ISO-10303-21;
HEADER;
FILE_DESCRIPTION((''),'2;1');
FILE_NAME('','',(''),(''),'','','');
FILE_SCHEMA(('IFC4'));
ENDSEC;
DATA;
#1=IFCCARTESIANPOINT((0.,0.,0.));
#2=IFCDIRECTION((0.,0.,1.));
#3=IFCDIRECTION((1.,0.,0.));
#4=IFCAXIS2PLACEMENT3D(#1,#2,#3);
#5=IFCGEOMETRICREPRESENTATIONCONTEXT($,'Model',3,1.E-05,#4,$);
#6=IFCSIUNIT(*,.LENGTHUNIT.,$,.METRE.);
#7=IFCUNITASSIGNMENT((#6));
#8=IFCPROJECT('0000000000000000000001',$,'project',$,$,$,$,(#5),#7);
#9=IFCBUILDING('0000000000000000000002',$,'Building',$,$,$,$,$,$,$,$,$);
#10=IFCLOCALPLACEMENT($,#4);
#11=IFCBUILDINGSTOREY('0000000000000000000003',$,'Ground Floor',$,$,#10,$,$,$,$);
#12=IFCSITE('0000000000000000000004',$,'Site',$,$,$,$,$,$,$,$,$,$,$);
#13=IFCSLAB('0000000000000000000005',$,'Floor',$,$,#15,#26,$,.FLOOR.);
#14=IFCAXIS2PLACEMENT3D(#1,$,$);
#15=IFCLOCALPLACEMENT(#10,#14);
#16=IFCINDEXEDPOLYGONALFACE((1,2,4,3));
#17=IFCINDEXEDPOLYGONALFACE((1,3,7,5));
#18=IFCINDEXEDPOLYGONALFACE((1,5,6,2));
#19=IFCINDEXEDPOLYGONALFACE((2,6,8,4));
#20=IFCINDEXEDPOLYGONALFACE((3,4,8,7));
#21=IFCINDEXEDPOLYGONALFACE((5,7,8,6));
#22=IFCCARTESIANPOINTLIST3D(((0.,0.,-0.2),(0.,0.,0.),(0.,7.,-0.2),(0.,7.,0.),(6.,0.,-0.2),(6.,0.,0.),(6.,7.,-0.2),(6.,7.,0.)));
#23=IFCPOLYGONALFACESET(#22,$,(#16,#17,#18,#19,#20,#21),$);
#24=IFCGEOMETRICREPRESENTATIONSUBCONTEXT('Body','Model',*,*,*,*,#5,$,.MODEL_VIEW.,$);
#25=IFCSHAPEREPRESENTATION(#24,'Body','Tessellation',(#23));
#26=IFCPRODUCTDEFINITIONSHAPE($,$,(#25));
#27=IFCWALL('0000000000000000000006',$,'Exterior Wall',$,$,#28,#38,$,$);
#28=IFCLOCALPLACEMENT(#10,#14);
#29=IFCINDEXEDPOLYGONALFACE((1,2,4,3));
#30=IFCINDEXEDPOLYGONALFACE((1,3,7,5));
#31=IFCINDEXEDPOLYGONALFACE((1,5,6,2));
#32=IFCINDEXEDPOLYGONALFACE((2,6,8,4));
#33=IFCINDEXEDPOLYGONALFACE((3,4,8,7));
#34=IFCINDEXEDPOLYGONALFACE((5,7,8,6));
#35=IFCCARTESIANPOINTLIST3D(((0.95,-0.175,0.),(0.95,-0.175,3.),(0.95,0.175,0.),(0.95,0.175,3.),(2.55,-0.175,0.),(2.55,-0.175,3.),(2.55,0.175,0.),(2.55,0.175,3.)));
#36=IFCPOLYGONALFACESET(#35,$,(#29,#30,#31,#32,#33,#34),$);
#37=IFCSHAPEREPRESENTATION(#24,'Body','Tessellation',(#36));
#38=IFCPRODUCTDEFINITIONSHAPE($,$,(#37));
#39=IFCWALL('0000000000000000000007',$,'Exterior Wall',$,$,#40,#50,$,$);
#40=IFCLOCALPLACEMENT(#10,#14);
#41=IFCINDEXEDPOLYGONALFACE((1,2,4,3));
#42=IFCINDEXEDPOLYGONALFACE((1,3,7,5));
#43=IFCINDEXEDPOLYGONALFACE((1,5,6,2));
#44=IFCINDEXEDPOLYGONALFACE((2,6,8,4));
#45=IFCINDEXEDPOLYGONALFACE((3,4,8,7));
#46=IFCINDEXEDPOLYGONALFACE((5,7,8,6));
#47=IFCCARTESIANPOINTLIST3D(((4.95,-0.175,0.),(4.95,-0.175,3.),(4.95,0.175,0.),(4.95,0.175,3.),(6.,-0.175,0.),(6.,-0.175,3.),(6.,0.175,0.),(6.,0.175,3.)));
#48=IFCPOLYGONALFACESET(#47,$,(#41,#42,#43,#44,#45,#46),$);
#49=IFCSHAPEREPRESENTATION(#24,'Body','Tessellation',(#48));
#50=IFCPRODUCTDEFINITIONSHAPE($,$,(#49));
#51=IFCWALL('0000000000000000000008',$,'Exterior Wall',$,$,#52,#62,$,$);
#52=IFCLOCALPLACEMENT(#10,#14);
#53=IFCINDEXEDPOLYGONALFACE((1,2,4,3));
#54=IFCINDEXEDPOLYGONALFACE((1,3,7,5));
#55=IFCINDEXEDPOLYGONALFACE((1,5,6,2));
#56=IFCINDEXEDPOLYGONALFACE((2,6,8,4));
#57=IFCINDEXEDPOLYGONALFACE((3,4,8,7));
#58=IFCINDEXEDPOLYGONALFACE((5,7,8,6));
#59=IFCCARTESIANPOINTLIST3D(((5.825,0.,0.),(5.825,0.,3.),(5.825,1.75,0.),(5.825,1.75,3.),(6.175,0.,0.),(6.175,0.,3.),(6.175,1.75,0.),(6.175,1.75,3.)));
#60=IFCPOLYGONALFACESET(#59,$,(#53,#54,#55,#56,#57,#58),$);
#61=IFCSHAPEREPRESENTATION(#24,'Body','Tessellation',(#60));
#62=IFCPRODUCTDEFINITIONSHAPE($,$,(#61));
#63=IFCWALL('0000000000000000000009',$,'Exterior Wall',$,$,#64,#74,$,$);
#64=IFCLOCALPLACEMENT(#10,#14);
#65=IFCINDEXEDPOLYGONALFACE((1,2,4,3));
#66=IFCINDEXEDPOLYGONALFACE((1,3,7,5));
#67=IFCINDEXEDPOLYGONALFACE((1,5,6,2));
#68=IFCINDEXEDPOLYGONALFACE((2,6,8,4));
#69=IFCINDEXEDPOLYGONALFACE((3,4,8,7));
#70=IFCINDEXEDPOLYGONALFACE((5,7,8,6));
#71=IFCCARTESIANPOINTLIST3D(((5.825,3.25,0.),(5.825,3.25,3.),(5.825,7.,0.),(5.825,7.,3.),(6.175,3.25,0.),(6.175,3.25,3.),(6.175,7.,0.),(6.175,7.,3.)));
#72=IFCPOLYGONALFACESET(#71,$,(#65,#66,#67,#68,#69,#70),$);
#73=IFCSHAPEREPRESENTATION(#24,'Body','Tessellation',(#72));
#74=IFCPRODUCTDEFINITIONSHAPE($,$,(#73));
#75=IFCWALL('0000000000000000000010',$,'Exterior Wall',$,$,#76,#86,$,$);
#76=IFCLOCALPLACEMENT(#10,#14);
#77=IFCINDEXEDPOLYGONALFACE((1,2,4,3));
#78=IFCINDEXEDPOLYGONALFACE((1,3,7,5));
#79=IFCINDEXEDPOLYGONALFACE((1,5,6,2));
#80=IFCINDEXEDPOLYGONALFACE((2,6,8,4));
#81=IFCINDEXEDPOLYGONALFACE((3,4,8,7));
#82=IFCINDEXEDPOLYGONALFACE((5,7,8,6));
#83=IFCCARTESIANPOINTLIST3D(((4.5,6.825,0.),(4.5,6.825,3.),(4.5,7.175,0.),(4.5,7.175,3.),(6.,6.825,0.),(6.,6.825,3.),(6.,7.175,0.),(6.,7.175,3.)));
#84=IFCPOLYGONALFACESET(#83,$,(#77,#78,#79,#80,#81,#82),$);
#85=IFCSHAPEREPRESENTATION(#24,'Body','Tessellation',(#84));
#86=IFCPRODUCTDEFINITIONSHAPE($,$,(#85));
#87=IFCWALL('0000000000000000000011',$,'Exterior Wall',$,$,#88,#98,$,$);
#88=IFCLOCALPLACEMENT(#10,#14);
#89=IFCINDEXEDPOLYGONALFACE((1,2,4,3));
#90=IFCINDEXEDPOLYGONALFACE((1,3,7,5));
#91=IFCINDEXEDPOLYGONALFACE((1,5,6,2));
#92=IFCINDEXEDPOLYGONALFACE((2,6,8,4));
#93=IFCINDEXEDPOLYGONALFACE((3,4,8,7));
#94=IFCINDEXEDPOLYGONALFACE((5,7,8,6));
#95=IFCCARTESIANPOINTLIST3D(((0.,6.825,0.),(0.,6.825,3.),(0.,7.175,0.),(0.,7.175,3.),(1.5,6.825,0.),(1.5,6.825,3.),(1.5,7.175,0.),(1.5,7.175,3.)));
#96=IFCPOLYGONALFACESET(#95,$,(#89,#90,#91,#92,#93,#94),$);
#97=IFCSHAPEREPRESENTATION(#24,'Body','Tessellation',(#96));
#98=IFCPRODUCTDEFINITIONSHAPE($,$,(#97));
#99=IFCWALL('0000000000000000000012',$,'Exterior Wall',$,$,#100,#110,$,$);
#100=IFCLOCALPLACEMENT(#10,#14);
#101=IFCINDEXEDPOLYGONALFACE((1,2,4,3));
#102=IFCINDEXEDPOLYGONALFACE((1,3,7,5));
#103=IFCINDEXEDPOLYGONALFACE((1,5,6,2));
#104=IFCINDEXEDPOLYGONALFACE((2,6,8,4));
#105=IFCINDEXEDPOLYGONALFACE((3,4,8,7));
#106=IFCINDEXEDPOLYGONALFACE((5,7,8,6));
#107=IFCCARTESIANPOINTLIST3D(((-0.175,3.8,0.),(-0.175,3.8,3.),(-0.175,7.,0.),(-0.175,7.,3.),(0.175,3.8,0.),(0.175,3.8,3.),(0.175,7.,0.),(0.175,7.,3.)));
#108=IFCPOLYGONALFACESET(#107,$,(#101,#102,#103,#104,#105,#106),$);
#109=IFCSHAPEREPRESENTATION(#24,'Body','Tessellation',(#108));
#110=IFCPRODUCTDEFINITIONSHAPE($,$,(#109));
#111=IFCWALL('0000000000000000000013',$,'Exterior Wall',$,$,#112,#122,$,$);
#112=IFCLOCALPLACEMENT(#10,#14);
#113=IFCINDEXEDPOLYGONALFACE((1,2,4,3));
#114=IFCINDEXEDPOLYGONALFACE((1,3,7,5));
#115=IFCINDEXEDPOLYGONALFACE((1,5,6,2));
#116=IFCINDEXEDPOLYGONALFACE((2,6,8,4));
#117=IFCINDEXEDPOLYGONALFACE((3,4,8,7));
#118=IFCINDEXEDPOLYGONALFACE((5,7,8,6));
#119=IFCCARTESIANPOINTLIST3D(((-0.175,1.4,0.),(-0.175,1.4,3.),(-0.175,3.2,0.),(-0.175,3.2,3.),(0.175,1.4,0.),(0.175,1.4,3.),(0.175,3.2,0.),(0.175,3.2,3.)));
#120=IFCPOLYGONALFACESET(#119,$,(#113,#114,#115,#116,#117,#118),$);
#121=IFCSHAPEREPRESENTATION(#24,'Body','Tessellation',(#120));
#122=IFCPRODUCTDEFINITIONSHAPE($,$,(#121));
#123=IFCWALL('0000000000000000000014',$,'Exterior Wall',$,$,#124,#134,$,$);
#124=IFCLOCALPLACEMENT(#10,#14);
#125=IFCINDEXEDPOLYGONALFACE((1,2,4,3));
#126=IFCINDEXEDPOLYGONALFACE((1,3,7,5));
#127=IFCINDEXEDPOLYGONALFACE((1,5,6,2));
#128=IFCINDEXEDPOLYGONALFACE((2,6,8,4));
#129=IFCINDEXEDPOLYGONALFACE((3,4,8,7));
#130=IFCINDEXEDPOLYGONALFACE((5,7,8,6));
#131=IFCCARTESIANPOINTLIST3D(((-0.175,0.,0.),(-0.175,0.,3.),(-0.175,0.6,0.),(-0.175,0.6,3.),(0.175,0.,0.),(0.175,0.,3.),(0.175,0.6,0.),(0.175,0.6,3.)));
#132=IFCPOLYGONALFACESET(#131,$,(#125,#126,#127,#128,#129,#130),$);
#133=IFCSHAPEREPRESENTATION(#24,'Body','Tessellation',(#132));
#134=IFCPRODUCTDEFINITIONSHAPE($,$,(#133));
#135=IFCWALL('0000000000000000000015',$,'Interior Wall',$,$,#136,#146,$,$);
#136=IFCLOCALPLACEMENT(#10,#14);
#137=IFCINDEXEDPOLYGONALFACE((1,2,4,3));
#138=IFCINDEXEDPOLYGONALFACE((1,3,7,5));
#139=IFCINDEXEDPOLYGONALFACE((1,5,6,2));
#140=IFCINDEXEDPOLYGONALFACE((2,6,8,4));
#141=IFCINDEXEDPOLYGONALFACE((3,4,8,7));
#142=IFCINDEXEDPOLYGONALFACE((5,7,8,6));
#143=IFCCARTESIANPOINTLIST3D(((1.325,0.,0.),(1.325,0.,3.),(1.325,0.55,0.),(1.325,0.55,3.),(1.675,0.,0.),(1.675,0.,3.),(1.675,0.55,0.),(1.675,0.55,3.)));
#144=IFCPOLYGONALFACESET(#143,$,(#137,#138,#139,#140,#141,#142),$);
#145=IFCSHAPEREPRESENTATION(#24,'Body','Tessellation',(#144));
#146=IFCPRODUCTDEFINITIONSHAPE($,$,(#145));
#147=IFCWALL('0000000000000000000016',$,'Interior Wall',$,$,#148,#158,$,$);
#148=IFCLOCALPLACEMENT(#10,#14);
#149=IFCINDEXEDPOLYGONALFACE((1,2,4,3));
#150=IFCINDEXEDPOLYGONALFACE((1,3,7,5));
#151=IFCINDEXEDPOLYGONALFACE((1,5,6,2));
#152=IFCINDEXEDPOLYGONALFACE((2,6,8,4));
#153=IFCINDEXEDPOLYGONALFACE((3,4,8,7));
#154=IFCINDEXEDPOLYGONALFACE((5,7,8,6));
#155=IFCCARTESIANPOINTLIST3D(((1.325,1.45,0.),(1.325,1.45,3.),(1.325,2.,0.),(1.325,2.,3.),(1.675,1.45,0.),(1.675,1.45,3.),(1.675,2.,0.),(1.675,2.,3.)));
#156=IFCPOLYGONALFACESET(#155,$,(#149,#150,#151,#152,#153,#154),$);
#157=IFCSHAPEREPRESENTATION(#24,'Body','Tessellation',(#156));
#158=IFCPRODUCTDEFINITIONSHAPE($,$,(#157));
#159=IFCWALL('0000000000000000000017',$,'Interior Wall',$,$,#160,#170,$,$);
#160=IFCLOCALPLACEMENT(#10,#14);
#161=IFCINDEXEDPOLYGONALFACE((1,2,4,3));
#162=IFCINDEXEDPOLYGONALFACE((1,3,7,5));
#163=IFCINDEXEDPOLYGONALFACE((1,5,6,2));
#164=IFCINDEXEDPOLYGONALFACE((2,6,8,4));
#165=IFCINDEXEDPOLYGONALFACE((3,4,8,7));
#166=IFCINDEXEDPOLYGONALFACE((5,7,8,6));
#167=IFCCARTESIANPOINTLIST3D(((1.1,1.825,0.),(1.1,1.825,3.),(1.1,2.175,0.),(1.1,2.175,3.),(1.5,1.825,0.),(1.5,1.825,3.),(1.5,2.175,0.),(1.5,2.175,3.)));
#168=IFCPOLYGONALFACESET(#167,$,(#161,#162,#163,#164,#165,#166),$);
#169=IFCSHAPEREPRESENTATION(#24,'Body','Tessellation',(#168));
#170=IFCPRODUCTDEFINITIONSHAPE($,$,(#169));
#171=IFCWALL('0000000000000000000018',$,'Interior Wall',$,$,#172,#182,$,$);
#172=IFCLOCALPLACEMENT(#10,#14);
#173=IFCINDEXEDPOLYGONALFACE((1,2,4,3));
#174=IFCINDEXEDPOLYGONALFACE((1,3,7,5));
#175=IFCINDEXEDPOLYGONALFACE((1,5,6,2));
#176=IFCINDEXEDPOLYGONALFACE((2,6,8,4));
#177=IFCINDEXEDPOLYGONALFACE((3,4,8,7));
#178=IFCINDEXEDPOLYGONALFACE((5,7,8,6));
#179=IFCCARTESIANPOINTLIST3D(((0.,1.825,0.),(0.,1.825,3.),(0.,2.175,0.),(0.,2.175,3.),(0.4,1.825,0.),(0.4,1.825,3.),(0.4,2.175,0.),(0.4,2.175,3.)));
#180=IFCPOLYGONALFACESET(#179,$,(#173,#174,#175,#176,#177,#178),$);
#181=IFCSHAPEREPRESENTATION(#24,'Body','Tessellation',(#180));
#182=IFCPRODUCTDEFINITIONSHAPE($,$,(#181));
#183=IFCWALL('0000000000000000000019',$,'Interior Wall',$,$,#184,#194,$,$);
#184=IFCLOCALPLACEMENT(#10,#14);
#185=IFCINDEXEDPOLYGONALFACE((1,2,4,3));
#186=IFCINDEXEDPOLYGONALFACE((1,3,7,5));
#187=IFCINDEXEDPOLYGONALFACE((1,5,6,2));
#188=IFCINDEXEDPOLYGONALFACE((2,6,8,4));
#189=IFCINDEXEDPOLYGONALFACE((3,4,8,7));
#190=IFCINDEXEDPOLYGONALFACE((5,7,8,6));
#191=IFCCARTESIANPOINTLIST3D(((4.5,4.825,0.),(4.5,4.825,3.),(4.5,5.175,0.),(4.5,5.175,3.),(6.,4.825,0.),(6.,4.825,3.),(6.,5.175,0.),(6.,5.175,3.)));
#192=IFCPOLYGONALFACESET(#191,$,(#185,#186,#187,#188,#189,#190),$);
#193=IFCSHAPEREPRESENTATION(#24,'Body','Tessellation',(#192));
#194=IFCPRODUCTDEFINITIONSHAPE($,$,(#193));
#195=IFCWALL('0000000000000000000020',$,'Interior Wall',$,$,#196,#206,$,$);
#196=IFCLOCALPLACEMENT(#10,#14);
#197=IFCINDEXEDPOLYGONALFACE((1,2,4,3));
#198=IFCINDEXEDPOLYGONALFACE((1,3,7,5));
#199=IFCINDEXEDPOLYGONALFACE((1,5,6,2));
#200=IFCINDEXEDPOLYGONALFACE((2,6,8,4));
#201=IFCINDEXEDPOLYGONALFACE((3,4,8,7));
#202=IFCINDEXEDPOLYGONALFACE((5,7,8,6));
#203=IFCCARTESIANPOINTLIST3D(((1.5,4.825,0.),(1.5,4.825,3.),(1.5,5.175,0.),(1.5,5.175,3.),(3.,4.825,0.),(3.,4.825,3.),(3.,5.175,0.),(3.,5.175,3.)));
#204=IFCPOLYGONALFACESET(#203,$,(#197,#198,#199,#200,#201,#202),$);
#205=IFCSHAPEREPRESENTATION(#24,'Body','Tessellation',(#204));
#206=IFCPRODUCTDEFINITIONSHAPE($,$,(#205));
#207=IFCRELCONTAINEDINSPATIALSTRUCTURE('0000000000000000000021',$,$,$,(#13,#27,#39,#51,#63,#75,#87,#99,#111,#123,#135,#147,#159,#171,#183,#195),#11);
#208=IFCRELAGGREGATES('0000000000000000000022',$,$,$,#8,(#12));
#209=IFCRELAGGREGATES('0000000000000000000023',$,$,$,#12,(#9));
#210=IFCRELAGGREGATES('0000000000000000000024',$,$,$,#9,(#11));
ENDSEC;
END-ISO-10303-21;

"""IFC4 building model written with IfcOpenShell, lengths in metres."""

from ifc_helpers import new_model, si_unit, frame, origin_with_axes, place, context, subcontext, project, spatial, indexed_curve, outline, extrude, element, save


model = new_model("IFC4")

# Units and contexts
model_context = context("Model", 3, precision=1e-05, world=origin_with_axes())
body_context = subcontext(model_context, "Body", "Model", "MODEL_VIEW")
ifc_project = project(units=[si_unit("LENGTHUNIT", "METRE")], contexts=[model_context])

# Site, building, storey
site = spatial("IfcSite", under=ifc_project, Name="Site")
building = spatial("IfcBuilding", under=site, Name="Building")
storey_placement = place(None, origin_with_axes())
storey = spatial("IfcBuildingStorey", under=building, at=storey_placement, Name="Ground Floor")

# Slab
slab_placement = place(storey_placement, frame((0.0, 0.0, -0.2), z_axis=(0.0, 0.0, 1.0), x_axis=(1.0, 0.0, 0.0)))
element("IfcSlab", 1, at=slab_placement, inside=storey, Name="Floor", PredefinedType="FLOOR", context=body_context, shape_type="SweptSolid", body=[
    extrude(outline(indexed_curve([(0.0, 0.0), (6.0, 0.0), (6.0, 7.0), (0.0, 7.0)])), None, (0.0, 0.0, 1.0), 0.2),
])

# Walls
wall_1_placement = place(storey_placement, frame((0.95, 0.0, 0.0), z_axis=(0.0, 0.0, 1.0), x_axis=(1.0, 0.0, 0.0)))
element("IfcWall", 2, at=wall_1_placement, inside=storey, Name="Exterior Wall", context=body_context, shape_type="SweptSolid", body=[
    extrude(outline(indexed_curve([(0.0, 0.0), (0.0, 0.35), (1.6, 0.35), (1.6, 0.0), (0.0, 0.0)], self_intersect=False)), frame((0.0, -0.175, 0.0), z_axis=(0.0, 0.0, 1.0), x_axis=(1.0, 0.0, 0.0)), (0.0, 0.0, 1.0), 3.0),
])
wall_2_placement = place(storey_placement, frame((4.95, 0.0, 0.0), z_axis=(0.0, 0.0, 1.0), x_axis=(1.0, 0.0, 0.0)))
element("IfcWall", 3, at=wall_2_placement, inside=storey, Name="Exterior Wall", context=body_context, shape_type="SweptSolid", body=[
    extrude(outline(indexed_curve([(0.0, 0.0), (0.0, 0.35), (1.05, 0.35), (1.05, 0.0), (0.0, 0.0)], self_intersect=False)), frame((0.0, -0.175, 0.0), z_axis=(0.0, 0.0, 1.0), x_axis=(1.0, 0.0, 0.0)), (0.0, 0.0, 1.0), 3.0),
])
wall_3_placement = place(storey_placement, frame((6.0, 0.0, 0.0), z_axis=(0.0, 0.0, 1.0), x_axis=(0.0, 1.0, 0.0)))
element("IfcWall", 4, at=wall_3_placement, inside=storey, Name="Exterior Wall", context=body_context, shape_type="SweptSolid", body=[
    extrude(outline(indexed_curve([(0.0, 0.0), (0.0, 0.35), (1.75, 0.35), (1.75, 0.0), (0.0, 0.0)], self_intersect=False)), frame((0.0, -0.175, 0.0), z_axis=(0.0, 0.0, 1.0), x_axis=(1.0, 0.0, 0.0)), (0.0, 0.0, 1.0), 3.0),
])
wall_4_placement = place(storey_placement, frame((6.0, 3.25, 0.0), z_axis=(0.0, 0.0, 1.0), x_axis=(0.0, 1.0, 0.0)))
element("IfcWall", 5, at=wall_4_placement, inside=storey, Name="Exterior Wall", context=body_context, shape_type="SweptSolid", body=[
    extrude(outline(indexed_curve([(0.0, 0.0), (0.0, 0.35), (3.75, 0.35), (3.75, 0.0), (0.0, 0.0)], self_intersect=False)), frame((0.0, -0.175, 0.0), z_axis=(0.0, 0.0, 1.0), x_axis=(1.0, 0.0, 0.0)), (0.0, 0.0, 1.0), 3.0),
])
for number, where, z_axis, x_axis, name in (
    (6, (6.0, 7.0, 0.0), (0.0, 0.0, 1.0), (-1.0, 0.0, 0.0), "Exterior Wall"),
    (7, (1.5, 7.0, 0.0), (0.0, 0.0, 1.0), (-1.0, 0.0, 0.0), "Exterior Wall"),
):
    element("IfcWall", number, at=place(storey_placement, frame(where, z_axis=z_axis, x_axis=x_axis)), inside=storey, Name=name, context=body_context, shape_type="SweptSolid", body=[
        extrude(outline(indexed_curve([(0.0, 0.0), (0.0, 0.35), (1.5, 0.35), (1.5, 0.0), (0.0, 0.0)], self_intersect=False)), frame((0.0, -0.175, 0.0), z_axis=(0.0, 0.0, 1.0), x_axis=(1.0, 0.0, 0.0)), (0.0, 0.0, 1.0), 3.0),
    ])
wall_5_placement = place(storey_placement, frame((0.0, 7.0, 0.0), z_axis=(0.0, 0.0, 1.0), x_axis=(0.0, -1.0, 0.0)))
element("IfcWall", 8, at=wall_5_placement, inside=storey, Name="Exterior Wall", context=body_context, shape_type="SweptSolid", body=[
    extrude(outline(indexed_curve([(0.0, 0.0), (0.0, 0.35), (3.2, 0.35), (3.2, 0.0), (0.0, 0.0)], self_intersect=False)), frame((0.0, -0.175, 0.0), z_axis=(0.0, 0.0, 1.0), x_axis=(1.0, 0.0, 0.0)), (0.0, 0.0, 1.0), 3.0),
])
wall_6_placement = place(storey_placement, frame((0.0, 3.2, 0.0), z_axis=(0.0, 0.0, 1.0), x_axis=(0.0, -1.0, 0.0)))
element("IfcWall", 9, at=wall_6_placement, inside=storey, Name="Exterior Wall", context=body_context, shape_type="SweptSolid", body=[
    extrude(outline(indexed_curve([(0.0, 0.0), (0.0, 0.35), (1.8, 0.35), (1.8, 0.0), (0.0, 0.0)], self_intersect=False)), frame((0.0, -0.175, 0.0), z_axis=(0.0, 0.0, 1.0), x_axis=(1.0, 0.0, 0.0)), (0.0, 0.0, 1.0), 3.0),
])
wall_7_placement = place(storey_placement, frame((0.0, 0.6, 0.0), z_axis=(0.0, 0.0, 1.0), x_axis=(0.0, -1.0, 0.0)))
element("IfcWall", 10, at=wall_7_placement, inside=storey, Name="Exterior Wall", context=body_context, shape_type="SweptSolid", body=[
    extrude(outline(indexed_curve([(0.0, 0.0), (0.0, 0.35), (0.6, 0.35), (0.6, 0.0), (0.0, 0.0)], self_intersect=False)), frame((0.0, -0.175, 0.0), z_axis=(0.0, 0.0, 1.0), x_axis=(1.0, 0.0, 0.0)), (0.0, 0.0, 1.0), 3.0),
])
for number, where, z_axis, x_axis, name in (
    (11, (1.5, 0.0, 0.0), (0.0, 0.0, 1.0), (0.0, 1.0, 0.0), "Interior Wall"),
    (12, (1.5, 1.45, 0.0), (0.0, 0.0, 1.0), (0.0, 1.0, 0.0), "Interior Wall"),
):
    element("IfcWall", number, at=place(storey_placement, frame(where, z_axis=z_axis, x_axis=x_axis)), inside=storey, Name=name, context=body_context, shape_type="SweptSolid", body=[
        extrude(outline(indexed_curve([(0.0, 0.0), (0.0, 0.35), (0.55, 0.35), (0.55, 0.0), (0.0, 0.0)], self_intersect=False)), frame((0.0, -0.175, 0.0), z_axis=(0.0, 0.0, 1.0), x_axis=(1.0, 0.0, 0.0)), (0.0, 0.0, 1.0), 3.0),
    ])
for number, where, z_axis, x_axis, name in (
    (13, (1.5, 2.0, 0.0), (0.0, 0.0, 1.0), (-1.0, 0.0, 0.0), "Interior Wall"),
    (14, (0.4, 2.0, 0.0), (0.0, 0.0, 1.0), (-1.0, 0.0, 0.0), "Interior Wall"),
):
    element("IfcWall", number, at=place(storey_placement, frame(where, z_axis=z_axis, x_axis=x_axis)), inside=storey, Name=name, context=body_context, shape_type="SweptSolid", body=[
        extrude(outline(indexed_curve([(0.0, 0.0), (0.0, 0.35), (0.4, 0.35), (0.4, 0.0), (0.0, 0.0)], self_intersect=False)), frame((0.0, -0.175, 0.0), z_axis=(0.0, 0.0, 1.0), x_axis=(1.0, 0.0, 0.0)), (0.0, 0.0, 1.0), 3.0),
    ])
for number, where, z_axis, x_axis, name in (
    (15, (6.0, 5.0, 0.0), (0.0, 0.0, 1.0), (-1.0, 0.0, 0.0), "Interior Wall"),
    (16, (3.0, 5.0, 0.0), (0.0, 0.0, 1.0), (-1.0, 0.0, 0.0), "Interior Wall"),
):
    element("IfcWall", number, at=place(storey_placement, frame(where, z_axis=z_axis, x_axis=x_axis)), inside=storey, Name=name, context=body_context, shape_type="SweptSolid", body=[
        extrude(outline(indexed_curve([(0.0, 0.0), (0.0, 0.35), (1.5, 0.35), (1.5, 0.0), (0.0, 0.0)], self_intersect=False)), frame((0.0, -0.175, 0.0), z_axis=(0.0, 0.0, 1.0), x_axis=(1.0, 0.0, 0.0)), (0.0, 0.0, 1.0), 3.0),
    ])

save(model, "model.ifc")
